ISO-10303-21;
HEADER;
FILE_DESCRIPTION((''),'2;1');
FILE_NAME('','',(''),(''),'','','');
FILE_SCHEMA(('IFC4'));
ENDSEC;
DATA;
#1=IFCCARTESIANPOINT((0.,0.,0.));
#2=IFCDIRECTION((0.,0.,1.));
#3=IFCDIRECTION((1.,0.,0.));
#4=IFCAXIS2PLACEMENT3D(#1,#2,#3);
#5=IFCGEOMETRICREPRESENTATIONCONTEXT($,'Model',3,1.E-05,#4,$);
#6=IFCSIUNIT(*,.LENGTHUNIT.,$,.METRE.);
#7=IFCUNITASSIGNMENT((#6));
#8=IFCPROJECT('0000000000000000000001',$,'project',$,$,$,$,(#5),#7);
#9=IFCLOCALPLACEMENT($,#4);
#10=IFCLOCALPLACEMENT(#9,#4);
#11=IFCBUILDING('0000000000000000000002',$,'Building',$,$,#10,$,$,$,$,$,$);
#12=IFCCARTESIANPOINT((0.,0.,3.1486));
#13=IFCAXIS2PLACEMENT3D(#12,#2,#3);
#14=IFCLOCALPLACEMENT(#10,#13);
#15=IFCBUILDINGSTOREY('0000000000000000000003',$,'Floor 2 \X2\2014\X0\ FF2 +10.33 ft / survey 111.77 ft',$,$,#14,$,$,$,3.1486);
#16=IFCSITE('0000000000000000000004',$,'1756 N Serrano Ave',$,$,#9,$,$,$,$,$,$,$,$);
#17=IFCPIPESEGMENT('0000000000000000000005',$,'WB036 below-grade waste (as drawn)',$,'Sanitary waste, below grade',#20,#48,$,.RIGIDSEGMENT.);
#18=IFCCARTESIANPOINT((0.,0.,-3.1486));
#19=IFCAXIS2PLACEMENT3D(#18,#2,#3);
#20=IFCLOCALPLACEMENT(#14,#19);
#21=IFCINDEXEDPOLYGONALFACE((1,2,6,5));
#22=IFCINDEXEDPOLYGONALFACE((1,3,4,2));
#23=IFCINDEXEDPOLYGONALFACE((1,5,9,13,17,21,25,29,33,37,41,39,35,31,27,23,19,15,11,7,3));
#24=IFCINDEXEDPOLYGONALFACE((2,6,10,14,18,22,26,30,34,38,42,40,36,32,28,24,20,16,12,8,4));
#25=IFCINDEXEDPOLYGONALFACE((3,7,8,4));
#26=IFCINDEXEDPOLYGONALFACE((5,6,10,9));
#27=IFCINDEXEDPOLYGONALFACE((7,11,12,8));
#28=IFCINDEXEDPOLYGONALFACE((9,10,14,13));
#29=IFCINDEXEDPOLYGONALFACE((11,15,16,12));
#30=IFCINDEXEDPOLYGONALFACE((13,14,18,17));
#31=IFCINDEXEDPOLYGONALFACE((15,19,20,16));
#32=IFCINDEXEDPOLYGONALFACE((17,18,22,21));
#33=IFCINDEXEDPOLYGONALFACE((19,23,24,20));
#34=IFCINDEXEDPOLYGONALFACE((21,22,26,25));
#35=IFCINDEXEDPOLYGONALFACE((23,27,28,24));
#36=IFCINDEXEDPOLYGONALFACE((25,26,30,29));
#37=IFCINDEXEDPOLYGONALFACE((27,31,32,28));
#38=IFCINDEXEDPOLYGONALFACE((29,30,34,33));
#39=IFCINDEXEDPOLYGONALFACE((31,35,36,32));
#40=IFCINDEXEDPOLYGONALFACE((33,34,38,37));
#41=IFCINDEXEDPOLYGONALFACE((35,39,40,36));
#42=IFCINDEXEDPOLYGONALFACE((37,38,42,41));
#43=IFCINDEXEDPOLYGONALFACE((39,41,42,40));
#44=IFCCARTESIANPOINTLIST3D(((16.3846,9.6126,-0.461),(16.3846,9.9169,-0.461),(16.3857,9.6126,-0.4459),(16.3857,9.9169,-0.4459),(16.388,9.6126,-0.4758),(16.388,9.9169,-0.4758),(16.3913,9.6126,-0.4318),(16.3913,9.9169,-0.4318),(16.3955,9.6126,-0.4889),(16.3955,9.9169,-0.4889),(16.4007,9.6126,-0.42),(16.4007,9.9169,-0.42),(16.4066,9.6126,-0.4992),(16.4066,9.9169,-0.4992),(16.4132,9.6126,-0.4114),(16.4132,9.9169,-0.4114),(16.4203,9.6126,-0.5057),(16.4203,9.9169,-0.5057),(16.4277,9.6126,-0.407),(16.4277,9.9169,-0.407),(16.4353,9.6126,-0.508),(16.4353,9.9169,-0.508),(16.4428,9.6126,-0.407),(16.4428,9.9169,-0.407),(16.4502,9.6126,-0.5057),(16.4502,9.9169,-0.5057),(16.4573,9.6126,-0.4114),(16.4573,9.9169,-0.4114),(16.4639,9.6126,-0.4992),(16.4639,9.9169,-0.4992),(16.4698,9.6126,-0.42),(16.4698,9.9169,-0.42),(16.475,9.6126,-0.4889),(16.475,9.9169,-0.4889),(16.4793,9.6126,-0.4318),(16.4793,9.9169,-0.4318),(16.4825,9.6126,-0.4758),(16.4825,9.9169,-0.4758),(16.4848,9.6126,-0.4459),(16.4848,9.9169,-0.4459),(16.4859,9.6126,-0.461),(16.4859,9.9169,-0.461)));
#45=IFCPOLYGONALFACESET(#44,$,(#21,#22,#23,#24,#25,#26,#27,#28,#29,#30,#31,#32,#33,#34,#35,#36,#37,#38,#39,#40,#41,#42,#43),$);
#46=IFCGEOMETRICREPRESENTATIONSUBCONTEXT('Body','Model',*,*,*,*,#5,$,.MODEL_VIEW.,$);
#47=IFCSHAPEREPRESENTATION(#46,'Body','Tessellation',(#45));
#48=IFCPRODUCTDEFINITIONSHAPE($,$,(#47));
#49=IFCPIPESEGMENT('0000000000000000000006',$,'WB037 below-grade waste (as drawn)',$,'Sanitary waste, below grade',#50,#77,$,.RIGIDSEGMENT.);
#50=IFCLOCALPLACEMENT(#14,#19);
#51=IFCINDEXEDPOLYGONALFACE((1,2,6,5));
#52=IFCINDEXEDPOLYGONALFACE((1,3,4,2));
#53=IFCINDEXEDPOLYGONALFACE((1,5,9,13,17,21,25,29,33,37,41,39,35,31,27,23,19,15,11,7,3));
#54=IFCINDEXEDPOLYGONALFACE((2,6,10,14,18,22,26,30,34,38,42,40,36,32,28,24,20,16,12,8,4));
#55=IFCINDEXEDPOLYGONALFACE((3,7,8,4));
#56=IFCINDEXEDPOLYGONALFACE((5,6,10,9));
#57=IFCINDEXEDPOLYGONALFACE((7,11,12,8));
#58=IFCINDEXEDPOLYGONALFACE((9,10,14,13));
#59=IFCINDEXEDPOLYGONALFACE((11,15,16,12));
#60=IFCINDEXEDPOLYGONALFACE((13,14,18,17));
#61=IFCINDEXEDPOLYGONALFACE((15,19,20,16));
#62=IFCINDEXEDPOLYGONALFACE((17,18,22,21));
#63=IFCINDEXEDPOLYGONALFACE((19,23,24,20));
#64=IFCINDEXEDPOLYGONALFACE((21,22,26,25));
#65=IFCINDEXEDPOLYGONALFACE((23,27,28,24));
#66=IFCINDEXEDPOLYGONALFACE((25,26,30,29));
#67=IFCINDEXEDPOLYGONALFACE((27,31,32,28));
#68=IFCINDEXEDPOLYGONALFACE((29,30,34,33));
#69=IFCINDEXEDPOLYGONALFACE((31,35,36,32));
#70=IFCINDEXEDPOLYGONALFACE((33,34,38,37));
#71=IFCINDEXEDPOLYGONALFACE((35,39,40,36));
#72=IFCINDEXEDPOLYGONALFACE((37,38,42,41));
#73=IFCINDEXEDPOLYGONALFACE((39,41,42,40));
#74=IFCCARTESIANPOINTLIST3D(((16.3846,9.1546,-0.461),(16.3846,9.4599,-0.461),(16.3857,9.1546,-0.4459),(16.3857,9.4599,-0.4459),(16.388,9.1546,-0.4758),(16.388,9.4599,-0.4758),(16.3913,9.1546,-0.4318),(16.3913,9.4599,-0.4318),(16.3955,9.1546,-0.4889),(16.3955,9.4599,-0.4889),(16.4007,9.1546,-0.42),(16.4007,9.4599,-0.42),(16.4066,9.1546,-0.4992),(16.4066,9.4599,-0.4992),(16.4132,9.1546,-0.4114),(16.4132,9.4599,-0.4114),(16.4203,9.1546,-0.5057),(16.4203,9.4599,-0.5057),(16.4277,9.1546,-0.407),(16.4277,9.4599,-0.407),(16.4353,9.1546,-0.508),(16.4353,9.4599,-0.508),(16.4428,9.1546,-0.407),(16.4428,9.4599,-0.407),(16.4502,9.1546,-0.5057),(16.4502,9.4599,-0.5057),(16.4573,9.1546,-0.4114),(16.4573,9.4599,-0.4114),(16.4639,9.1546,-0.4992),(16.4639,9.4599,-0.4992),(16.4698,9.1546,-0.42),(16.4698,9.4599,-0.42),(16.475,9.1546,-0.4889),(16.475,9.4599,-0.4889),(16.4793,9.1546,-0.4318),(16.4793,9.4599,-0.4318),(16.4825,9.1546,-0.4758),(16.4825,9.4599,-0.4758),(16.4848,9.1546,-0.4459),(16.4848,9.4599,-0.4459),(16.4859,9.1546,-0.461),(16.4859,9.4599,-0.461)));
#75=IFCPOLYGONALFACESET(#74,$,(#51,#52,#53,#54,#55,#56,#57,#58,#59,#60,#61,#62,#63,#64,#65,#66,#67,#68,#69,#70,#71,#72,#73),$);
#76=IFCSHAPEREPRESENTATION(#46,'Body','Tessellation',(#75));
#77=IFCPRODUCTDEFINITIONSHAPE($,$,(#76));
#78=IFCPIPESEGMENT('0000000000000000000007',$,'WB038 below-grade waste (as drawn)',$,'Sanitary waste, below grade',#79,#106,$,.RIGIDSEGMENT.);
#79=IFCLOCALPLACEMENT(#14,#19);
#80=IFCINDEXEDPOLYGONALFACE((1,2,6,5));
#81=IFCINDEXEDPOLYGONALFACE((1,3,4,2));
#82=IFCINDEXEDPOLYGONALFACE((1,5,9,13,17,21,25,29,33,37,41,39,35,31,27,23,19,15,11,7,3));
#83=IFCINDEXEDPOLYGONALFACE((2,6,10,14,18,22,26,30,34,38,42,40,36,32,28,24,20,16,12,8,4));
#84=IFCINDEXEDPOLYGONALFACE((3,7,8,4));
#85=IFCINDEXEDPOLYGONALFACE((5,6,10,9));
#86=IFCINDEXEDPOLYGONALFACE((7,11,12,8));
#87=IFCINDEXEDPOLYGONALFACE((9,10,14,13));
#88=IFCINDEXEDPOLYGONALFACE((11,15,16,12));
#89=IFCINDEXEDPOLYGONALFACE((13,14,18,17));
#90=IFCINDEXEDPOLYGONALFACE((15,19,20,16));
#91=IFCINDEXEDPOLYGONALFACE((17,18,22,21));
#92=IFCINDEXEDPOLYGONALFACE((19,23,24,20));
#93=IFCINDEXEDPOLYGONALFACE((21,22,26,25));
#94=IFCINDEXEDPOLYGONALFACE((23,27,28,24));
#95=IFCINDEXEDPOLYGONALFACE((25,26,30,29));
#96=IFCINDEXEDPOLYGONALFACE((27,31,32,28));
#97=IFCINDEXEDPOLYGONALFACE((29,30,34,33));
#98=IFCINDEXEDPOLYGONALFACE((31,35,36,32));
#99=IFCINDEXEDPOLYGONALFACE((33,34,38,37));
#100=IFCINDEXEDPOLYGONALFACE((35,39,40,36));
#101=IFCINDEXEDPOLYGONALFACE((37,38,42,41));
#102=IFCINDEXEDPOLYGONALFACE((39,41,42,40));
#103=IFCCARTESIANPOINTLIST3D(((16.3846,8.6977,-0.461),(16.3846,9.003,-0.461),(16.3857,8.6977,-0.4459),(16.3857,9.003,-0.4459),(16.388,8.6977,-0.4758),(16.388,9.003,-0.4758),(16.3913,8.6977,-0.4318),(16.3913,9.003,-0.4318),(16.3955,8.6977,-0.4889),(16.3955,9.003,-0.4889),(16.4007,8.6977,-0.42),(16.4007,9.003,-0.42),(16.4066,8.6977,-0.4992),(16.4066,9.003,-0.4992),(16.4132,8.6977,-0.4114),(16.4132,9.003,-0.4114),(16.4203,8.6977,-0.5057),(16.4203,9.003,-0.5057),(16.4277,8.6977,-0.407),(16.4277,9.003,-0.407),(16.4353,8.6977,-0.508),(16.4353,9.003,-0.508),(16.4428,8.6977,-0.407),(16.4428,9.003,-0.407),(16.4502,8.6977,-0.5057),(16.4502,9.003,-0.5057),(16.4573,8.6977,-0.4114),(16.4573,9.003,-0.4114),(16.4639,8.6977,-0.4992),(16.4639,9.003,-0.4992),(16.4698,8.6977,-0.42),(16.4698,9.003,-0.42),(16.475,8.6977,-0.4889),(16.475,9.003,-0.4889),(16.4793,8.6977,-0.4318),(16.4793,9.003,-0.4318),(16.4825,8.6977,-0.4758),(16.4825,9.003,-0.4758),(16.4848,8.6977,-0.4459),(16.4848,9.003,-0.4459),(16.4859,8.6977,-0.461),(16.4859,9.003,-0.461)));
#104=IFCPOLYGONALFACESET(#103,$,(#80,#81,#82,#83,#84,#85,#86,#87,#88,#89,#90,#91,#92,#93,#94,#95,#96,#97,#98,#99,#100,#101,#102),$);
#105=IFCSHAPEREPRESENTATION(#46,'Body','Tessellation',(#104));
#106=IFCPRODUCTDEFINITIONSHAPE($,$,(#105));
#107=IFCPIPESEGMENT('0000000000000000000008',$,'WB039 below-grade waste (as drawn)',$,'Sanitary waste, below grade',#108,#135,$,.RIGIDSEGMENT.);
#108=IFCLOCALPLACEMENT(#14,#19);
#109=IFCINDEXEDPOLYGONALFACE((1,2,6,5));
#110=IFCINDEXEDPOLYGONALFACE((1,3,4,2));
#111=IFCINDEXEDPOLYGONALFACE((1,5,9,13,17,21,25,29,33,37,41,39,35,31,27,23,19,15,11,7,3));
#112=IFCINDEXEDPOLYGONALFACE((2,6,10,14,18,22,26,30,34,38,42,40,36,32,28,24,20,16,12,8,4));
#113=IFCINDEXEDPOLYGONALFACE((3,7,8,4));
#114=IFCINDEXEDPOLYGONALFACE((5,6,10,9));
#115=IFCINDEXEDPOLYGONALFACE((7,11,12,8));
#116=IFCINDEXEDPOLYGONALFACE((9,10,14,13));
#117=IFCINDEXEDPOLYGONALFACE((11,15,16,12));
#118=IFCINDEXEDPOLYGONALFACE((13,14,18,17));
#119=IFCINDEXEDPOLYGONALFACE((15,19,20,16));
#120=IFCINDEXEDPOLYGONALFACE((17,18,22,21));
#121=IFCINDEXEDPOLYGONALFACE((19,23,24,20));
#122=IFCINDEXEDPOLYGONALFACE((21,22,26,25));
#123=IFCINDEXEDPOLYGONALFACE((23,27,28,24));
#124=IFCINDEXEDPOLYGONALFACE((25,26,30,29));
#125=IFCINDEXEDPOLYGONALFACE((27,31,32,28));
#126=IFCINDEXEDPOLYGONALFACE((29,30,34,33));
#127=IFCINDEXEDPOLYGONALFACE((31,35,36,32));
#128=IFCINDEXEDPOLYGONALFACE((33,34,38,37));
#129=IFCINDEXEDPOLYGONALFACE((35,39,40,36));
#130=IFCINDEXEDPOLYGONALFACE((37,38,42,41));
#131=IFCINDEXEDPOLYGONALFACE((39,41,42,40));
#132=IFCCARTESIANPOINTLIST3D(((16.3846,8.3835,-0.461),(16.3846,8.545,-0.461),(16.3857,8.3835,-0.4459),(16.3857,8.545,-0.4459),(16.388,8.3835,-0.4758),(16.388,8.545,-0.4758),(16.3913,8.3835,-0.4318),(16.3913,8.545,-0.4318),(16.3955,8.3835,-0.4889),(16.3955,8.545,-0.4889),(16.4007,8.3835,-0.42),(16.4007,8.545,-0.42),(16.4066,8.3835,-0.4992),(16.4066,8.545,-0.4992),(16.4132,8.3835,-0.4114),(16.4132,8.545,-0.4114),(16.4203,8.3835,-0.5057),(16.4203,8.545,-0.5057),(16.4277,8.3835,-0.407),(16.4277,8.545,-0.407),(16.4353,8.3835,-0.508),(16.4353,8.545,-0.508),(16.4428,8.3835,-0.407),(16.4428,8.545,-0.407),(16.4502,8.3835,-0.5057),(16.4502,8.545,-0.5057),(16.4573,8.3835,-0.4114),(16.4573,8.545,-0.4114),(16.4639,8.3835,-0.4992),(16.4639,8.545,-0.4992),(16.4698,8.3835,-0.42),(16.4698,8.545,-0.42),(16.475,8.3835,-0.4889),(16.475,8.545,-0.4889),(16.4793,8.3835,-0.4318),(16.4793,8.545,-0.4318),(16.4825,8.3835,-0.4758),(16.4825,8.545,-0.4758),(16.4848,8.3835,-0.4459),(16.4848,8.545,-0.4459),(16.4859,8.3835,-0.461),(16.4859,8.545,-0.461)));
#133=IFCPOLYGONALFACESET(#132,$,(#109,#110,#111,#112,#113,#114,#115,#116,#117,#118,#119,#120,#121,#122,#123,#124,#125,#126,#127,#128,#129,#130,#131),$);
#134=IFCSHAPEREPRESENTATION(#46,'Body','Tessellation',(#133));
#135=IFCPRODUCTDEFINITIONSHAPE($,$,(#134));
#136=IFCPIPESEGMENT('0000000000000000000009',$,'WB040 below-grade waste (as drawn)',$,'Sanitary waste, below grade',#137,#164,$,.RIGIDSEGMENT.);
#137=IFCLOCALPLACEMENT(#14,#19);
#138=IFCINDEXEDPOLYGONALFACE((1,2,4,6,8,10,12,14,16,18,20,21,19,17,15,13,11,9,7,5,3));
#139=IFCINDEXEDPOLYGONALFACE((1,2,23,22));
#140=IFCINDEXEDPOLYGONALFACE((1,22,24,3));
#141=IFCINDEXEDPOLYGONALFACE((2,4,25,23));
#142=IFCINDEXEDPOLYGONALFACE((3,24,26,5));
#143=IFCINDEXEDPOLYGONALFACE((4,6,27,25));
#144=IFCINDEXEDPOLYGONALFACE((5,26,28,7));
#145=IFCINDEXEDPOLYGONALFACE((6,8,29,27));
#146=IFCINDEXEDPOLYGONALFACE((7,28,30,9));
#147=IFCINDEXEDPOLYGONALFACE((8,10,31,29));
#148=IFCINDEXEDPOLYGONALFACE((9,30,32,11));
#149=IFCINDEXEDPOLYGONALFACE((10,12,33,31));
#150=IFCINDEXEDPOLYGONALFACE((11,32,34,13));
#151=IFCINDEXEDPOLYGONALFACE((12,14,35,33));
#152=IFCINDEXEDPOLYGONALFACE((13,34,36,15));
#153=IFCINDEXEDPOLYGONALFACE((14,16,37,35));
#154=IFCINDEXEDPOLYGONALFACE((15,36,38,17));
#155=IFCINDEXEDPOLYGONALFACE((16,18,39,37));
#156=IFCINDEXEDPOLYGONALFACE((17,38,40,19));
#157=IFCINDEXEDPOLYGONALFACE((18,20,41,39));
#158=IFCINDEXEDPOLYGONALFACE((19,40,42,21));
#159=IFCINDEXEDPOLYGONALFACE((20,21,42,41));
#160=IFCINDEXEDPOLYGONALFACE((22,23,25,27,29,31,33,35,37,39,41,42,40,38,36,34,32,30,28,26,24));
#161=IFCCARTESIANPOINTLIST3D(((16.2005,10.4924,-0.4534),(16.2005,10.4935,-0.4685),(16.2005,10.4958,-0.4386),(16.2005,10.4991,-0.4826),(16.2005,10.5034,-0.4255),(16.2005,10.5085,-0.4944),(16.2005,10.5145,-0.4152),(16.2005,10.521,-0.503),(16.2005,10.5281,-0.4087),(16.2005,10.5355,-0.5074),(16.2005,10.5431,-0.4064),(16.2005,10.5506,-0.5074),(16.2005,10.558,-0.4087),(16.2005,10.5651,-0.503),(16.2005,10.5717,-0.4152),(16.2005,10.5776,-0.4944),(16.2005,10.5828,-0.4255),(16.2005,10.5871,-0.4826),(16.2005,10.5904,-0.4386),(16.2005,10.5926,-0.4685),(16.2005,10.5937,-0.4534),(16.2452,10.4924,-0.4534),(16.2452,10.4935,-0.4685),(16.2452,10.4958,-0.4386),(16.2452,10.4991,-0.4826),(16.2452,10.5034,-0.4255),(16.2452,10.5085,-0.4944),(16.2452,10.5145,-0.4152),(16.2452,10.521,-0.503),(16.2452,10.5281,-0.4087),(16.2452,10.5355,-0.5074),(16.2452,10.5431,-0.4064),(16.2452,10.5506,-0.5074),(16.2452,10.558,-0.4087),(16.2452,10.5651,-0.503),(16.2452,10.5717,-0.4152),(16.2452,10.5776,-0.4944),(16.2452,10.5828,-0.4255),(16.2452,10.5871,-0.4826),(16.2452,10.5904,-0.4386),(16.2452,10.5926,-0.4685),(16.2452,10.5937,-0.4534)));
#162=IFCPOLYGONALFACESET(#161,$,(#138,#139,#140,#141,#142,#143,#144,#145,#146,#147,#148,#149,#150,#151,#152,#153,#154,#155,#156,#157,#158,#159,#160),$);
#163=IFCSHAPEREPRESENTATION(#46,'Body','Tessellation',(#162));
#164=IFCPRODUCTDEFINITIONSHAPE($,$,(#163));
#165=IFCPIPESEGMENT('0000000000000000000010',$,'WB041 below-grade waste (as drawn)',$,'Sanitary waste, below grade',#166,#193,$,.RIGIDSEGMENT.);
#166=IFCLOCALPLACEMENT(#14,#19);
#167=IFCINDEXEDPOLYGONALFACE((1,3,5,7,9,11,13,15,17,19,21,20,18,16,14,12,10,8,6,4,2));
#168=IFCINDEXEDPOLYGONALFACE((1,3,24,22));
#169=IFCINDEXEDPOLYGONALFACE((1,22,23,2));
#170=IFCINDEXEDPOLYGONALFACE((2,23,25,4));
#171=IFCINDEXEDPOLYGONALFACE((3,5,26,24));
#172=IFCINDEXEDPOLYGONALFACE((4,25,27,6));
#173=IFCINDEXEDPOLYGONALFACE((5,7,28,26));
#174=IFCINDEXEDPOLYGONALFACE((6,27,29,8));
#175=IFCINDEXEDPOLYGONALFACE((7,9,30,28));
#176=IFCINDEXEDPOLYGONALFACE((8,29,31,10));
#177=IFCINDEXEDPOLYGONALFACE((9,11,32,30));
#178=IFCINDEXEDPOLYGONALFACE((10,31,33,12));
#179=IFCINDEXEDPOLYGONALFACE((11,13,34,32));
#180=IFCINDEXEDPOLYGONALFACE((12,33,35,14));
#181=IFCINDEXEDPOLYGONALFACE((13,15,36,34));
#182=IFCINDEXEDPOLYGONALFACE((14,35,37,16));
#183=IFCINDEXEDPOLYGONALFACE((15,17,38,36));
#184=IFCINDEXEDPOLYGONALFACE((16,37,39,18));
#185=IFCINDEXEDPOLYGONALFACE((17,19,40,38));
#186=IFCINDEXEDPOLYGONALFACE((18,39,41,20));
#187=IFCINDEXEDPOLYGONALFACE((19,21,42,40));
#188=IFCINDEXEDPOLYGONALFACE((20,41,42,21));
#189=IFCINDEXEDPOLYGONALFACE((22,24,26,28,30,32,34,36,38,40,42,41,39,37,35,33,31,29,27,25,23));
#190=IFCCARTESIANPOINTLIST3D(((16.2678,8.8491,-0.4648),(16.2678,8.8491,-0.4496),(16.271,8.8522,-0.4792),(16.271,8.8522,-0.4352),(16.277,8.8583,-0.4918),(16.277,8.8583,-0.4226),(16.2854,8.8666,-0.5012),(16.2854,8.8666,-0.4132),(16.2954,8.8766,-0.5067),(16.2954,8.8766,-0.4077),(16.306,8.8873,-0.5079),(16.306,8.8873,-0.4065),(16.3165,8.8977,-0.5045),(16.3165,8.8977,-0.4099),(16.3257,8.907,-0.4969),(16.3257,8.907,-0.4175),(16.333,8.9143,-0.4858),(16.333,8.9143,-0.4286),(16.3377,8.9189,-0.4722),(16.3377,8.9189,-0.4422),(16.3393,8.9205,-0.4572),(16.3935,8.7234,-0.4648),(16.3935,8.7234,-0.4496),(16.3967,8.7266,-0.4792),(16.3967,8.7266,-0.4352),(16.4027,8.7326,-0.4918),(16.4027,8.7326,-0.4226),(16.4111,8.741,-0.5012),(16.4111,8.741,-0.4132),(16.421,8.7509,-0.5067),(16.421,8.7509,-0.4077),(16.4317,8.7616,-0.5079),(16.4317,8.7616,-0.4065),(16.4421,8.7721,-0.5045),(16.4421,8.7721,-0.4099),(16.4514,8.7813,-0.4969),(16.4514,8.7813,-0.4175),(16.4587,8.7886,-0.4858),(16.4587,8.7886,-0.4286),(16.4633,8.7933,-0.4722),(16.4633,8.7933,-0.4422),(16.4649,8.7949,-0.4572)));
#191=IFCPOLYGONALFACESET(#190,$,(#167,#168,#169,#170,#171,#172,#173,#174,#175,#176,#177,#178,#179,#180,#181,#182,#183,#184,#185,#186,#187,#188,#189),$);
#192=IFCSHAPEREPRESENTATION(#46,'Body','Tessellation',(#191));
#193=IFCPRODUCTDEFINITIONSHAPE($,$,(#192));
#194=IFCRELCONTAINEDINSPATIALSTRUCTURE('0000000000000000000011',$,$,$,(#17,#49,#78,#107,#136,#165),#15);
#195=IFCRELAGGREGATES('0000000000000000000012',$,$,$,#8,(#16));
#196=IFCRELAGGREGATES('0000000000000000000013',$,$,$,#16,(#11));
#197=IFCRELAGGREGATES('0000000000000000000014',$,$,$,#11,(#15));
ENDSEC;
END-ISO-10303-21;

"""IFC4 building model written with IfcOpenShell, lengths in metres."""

from ifc_helpers import new_model, entity, si_unit, frame, origin_with_axes, place, context, subcontext, project, spatial, element, save


model = new_model("IFC4")

# Units and contexts
model_context = context("Model", 3, precision=1e-05, world=origin_with_axes())
body_context = subcontext(model_context, "Body", "Model", "MODEL_VIEW")
ifc_project = project(units=[si_unit("LENGTHUNIT", "METRE")], contexts=[model_context])

# Site, building, storey
site_placement = place(None, origin_with_axes())
site = spatial("IfcSite", under=ifc_project, at=site_placement, Name="1756 N Serrano Ave")
building_placement = place(site_placement, origin_with_axes())
building = spatial("IfcBuilding", under=site, at=building_placement, Name="Building")
storey_placement = place(building_placement, frame((0.0, 0.0, 3.1486), z_axis=(0.0, 0.0, 1.0), x_axis=(1.0, 0.0, 0.0)))
storey = spatial("IfcBuildingStorey", under=building, at=storey_placement, Name="Floor 2 — FF2 +10.33 ft / survey 111.77 ft", Elevation=3.1486)

# Pipe segments
pipe_segment_1_placement = place(storey_placement, frame((0.0, 0.0, -3.1486), z_axis=(0.0, 0.0, 1.0), x_axis=(1.0, 0.0, 0.0)))
element("IfcPipeSegment", 1, at=pipe_segment_1_placement, inside=storey, Name="WB036 below-grade waste (as drawn)", ObjectType="Sanitary waste, below grade", PredefinedType="RIGIDSEGMENT", context=body_context, shape_type="AdvancedSweptSolid", body=[
    entity("IfcSweptDiskSolid", entity("IfcPolyline", [entity("IfcCartesianPoint", [16.4353, 9.9169, -0.4572]), entity("IfcCartesianPoint", [16.4353, 9.6126, -0.4572])]), 0.0508),
])
pipe_segment_2_placement = place(storey_placement, frame((0.0, 0.0, -3.1486), z_axis=(0.0, 0.0, 1.0), x_axis=(1.0, 0.0, 0.0)))
element("IfcPipeSegment", 2, at=pipe_segment_2_placement, inside=storey, Name="WB037 below-grade waste (as drawn)", ObjectType="Sanitary waste, below grade", PredefinedType="RIGIDSEGMENT", context=body_context, shape_type="AdvancedSweptSolid", body=[
    entity("IfcSweptDiskSolid", entity("IfcPolyline", [entity("IfcCartesianPoint", [16.4353, 9.4599, -0.4572]), entity("IfcCartesianPoint", [16.4353, 9.1546, -0.4572])]), 0.0508),
])
pipe_segment_3_placement = place(storey_placement, frame((0.0, 0.0, -3.1486), z_axis=(0.0, 0.0, 1.0), x_axis=(1.0, 0.0, 0.0)))
element("IfcPipeSegment", 3, at=pipe_segment_3_placement, inside=storey, Name="WB038 below-grade waste (as drawn)", ObjectType="Sanitary waste, below grade", PredefinedType="RIGIDSEGMENT", context=body_context, shape_type="AdvancedSweptSolid", body=[
    entity("IfcSweptDiskSolid", entity("IfcPolyline", [entity("IfcCartesianPoint", [16.4353, 9.003, -0.4572]), entity("IfcCartesianPoint", [16.4353, 8.6977, -0.4572])]), 0.0508),
])
pipe_segment_4_placement = place(storey_placement, frame((0.0, 0.0, -3.1486), z_axis=(0.0, 0.0, 1.0), x_axis=(1.0, 0.0, 0.0)))
element("IfcPipeSegment", 4, at=pipe_segment_4_placement, inside=storey, Name="WB039 below-grade waste (as drawn)", ObjectType="Sanitary waste, below grade", PredefinedType="RIGIDSEGMENT", context=body_context, shape_type="AdvancedSweptSolid", body=[
    entity("IfcSweptDiskSolid", entity("IfcPolyline", [entity("IfcCartesianPoint", [16.4353, 8.545, -0.4572]), entity("IfcCartesianPoint", [16.4353, 8.3835, -0.4572])]), 0.0508),
])
pipe_segment_5_placement = place(storey_placement, frame((0.0, 0.0, -3.1486), z_axis=(0.0, 0.0, 1.0), x_axis=(1.0, 0.0, 0.0)))
element("IfcPipeSegment", 5, at=pipe_segment_5_placement, inside=storey, Name="WB040 below-grade waste (as drawn)", ObjectType="Sanitary waste, below grade", PredefinedType="RIGIDSEGMENT", context=body_context, shape_type="AdvancedSweptSolid", body=[
    entity("IfcSweptDiskSolid", entity("IfcPolyline", [entity("IfcCartesianPoint", [16.2005, 10.5431, -0.4572]), entity("IfcCartesianPoint", [16.2452, 10.5431, -0.4572])]), 0.0508),
])
pipe_segment_6_placement = place(storey_placement, frame((0.0, 0.0, -3.1486), z_axis=(0.0, 0.0, 1.0), x_axis=(1.0, 0.0, 0.0)))
element("IfcPipeSegment", 6, at=pipe_segment_6_placement, inside=storey, Name="WB041 below-grade waste (as drawn)", ObjectType="Sanitary waste, below grade", PredefinedType="RIGIDSEGMENT", context=body_context, shape_type="AdvancedSweptSolid", body=[
    entity("IfcSweptDiskSolid", entity("IfcPolyline", [entity("IfcCartesianPoint", [16.3033, 8.8846, -0.4572]), entity("IfcCartesianPoint", [16.429, 8.7589, -0.4572])]), 0.0508),
])

save(model, "model.ifc")
